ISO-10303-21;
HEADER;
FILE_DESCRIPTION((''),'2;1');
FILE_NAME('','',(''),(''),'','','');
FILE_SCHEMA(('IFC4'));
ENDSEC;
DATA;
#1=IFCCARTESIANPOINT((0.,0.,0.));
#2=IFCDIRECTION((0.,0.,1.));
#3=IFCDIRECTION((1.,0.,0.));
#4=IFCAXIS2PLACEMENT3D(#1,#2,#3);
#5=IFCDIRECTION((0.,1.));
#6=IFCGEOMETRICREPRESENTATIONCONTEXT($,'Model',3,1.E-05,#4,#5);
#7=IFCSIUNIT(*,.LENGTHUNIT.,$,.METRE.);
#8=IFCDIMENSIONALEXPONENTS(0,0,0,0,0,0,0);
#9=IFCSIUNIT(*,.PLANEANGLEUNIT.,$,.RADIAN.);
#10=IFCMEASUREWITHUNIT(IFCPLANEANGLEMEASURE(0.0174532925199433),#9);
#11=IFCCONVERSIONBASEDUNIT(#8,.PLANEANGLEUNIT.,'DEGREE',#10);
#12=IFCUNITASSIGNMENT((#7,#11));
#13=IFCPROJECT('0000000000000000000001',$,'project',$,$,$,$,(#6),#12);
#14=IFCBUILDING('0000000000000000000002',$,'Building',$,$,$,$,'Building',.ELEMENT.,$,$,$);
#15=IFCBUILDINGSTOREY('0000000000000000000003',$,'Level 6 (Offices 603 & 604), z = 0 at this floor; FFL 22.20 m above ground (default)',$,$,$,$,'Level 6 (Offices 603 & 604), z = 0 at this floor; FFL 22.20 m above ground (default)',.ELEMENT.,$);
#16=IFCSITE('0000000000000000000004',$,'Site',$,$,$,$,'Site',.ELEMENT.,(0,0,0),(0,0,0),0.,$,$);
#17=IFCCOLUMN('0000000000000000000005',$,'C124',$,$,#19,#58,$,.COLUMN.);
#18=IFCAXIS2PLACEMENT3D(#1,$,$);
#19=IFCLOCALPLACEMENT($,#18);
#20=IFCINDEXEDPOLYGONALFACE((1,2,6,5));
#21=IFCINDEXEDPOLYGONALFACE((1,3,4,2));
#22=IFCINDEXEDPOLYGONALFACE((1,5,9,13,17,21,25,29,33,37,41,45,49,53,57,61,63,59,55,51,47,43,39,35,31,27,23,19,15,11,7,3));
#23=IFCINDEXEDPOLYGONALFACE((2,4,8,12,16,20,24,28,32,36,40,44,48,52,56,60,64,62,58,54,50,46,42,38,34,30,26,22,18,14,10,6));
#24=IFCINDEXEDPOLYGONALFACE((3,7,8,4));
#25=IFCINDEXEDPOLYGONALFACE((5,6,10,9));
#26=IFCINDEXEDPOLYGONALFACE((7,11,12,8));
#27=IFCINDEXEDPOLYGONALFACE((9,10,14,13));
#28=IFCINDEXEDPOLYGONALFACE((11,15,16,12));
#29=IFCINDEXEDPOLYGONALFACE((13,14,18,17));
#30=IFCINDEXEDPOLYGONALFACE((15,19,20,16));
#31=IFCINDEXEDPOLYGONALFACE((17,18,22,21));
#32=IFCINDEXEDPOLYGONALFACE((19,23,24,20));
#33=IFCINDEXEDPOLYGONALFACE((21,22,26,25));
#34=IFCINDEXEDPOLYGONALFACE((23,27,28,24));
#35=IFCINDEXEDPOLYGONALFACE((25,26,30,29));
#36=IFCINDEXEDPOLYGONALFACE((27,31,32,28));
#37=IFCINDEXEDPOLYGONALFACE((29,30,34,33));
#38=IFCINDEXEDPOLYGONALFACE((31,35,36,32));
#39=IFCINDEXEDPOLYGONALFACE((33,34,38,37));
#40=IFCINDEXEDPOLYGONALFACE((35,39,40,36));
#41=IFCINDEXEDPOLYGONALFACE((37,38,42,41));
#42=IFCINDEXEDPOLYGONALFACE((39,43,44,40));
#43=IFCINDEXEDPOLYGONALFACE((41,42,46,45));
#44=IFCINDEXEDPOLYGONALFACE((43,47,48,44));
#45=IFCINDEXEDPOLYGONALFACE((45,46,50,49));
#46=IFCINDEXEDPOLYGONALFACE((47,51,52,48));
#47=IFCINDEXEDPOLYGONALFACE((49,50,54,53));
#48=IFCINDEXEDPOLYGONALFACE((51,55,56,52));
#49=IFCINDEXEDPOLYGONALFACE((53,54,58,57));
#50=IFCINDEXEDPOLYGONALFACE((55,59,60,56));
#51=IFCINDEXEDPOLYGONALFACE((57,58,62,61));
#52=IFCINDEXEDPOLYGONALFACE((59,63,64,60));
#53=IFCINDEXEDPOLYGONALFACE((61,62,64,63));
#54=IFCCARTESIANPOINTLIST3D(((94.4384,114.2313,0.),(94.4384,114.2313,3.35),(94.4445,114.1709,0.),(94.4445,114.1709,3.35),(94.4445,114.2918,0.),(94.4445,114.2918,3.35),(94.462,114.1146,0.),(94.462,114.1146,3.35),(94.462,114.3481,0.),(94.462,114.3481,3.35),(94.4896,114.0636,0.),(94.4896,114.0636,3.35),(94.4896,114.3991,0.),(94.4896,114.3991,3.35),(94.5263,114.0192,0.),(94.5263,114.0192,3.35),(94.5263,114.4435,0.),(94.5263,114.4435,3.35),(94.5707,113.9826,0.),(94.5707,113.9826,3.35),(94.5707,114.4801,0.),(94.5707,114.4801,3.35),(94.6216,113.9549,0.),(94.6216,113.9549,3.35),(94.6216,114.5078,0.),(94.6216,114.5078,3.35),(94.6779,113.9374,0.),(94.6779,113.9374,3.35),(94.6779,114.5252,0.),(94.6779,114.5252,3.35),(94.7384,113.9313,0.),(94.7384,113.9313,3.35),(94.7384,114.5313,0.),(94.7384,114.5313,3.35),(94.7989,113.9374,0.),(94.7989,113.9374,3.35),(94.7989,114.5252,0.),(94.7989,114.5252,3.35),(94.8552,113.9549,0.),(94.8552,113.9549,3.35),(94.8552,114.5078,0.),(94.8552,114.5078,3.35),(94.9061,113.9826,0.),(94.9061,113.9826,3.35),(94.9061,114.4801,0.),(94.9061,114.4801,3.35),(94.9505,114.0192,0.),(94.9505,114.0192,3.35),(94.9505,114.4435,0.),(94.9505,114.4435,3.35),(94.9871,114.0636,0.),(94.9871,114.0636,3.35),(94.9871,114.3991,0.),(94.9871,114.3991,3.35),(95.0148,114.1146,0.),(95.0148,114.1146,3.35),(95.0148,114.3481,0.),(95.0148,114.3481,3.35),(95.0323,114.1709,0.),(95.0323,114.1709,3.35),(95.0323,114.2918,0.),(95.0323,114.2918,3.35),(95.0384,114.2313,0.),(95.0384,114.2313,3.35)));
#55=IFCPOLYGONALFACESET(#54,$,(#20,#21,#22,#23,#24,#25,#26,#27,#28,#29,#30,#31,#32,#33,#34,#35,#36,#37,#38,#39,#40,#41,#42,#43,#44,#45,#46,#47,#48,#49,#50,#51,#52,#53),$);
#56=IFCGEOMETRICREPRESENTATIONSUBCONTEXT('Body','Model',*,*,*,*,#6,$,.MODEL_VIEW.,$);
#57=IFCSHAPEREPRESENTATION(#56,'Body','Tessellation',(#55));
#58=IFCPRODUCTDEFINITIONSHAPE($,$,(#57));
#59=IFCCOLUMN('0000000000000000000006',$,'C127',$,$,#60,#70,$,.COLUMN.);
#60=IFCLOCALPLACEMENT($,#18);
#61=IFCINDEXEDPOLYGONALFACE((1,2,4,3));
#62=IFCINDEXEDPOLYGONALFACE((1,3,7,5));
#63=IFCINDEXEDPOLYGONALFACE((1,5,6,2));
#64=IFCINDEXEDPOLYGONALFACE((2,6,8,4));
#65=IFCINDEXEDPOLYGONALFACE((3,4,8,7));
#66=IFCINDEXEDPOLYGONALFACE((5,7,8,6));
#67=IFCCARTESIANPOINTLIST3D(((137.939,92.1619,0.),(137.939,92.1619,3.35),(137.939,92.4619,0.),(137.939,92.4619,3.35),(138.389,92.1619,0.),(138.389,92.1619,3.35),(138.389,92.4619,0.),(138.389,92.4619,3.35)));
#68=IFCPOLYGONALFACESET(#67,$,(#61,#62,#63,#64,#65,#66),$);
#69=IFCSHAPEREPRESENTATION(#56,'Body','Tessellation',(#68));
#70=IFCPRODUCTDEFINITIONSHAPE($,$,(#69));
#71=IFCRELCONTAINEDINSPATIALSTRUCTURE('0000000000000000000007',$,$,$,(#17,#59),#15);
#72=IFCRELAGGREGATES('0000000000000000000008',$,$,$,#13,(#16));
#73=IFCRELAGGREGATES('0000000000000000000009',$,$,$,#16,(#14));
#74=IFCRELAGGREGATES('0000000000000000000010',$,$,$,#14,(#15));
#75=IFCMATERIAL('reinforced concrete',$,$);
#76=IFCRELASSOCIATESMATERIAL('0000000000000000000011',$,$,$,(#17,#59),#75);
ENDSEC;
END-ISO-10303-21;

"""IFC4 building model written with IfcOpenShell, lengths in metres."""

from ifc_helpers import new_model, entity, si_unit, converted_unit, direction, frame, frame_2d, origin_with_axes, place, context, subcontext, project, spatial, polyline, rectangle, outline, extrude, material, element, save


model = new_model("IFC4")

# Units and contexts
model_context = context("Model", 3, precision=1e-05, world=origin_with_axes(), true_north=direction((0.0, 1.0)))
body_context = subcontext(model_context, "Body", "Model", "MODEL_VIEW")
ifc_project = project(units=[si_unit("LENGTHUNIT", "METRE"), converted_unit("PLANEANGLEUNIT", "DEGREE", entity("IfcPlaneAngleMeasure", 0.0174532925199433), si_unit("PLANEANGLEUNIT", "RADIAN"), dimensions=[0, 0, 0, 0, 0, 0, 0])], contexts=[model_context])

# Site, building, storey
site = spatial("IfcSite", under=ifc_project, Name="Site", LongName="Site", CompositionType="ELEMENT", RefLatitude=(0, 0, 0), RefLongitude=(0, 0, 0), RefElevation=0.0)
building = spatial("IfcBuilding", under=site, Name="Building", LongName="Building", CompositionType="ELEMENT")
storey = spatial("IfcBuildingStorey", under=building, Name="Level 6 (Offices 603 & 604), z = 0 at this floor; FFL 22.20 m above ground (default)", LongName="Level 6 (Offices 603 & 604), z = 0 at this floor; FFL 22.20 m above ground (default)", CompositionType="ELEMENT")

# Columns
ifc_material_1 = material(Name="reinforced concrete")
placement = place(None, origin_with_axes())
element("IfcColumn", 1, at=placement, inside=storey, material=ifc_material_1, Name="C124", PredefinedType="COLUMN", context=body_context, shape_type="SweptSolid", body=[
    extrude(outline(polyline([(0.3, 0.0), (0.2939, -0.0604), (0.2764, -0.1167), (0.2487, -0.1677), (0.2121, -0.2121), (0.1677, -0.2487), (0.1168, -0.2764), (0.0605, -0.2939), (0.0, -0.3), (-0.0605, -0.2939), (-0.1168, -0.2764), (-0.1677, -0.2487), (-0.2121, -0.2121), (-0.2488, -0.1677), (-0.2764, -0.1167), (-0.2939, -0.0604), (-0.3, 0.0), (-0.2939, 0.0605), (-0.2764, 0.1168), (-0.2488, 0.1678), (-0.2121, 0.2122), (-0.1677, 0.2488), (-0.1168, 0.2765), (-0.0605, 0.2939), (0.0, 0.3), (0.0605, 0.2939), (0.1168, 0.2765), (0.1677, 0.2488), (0.2121, 0.2122), (0.2487, 0.1678), (0.2764, 0.1168), (0.2939, 0.0605), (0.3, 0.0)])), frame((94.7384, 114.2313, 0.0), z_axis=(0.0, 0.0, 1.0), x_axis=(1.0, 0.0, 0.0)), (0.0, 0.0, 1.0), 3.35),
])
element("IfcColumn", 2, at=placement, inside=storey, material=ifc_material_1, Name="C127", PredefinedType="COLUMN", context=body_context, shape_type="SweptSolid", body=[
    extrude(rectangle(XDim=0.3, YDim=0.45, at=frame_2d((0.0, 0.0), x_axis=(0.0, -1.0))), frame((138.164, 92.3119, 0.0), z_axis=(0.0, 0.0, 1.0), x_axis=(1.0, 0.0, 0.0)), (0.0, 0.0, 1.0), 3.35),
])

save(model, "model.ifc")
